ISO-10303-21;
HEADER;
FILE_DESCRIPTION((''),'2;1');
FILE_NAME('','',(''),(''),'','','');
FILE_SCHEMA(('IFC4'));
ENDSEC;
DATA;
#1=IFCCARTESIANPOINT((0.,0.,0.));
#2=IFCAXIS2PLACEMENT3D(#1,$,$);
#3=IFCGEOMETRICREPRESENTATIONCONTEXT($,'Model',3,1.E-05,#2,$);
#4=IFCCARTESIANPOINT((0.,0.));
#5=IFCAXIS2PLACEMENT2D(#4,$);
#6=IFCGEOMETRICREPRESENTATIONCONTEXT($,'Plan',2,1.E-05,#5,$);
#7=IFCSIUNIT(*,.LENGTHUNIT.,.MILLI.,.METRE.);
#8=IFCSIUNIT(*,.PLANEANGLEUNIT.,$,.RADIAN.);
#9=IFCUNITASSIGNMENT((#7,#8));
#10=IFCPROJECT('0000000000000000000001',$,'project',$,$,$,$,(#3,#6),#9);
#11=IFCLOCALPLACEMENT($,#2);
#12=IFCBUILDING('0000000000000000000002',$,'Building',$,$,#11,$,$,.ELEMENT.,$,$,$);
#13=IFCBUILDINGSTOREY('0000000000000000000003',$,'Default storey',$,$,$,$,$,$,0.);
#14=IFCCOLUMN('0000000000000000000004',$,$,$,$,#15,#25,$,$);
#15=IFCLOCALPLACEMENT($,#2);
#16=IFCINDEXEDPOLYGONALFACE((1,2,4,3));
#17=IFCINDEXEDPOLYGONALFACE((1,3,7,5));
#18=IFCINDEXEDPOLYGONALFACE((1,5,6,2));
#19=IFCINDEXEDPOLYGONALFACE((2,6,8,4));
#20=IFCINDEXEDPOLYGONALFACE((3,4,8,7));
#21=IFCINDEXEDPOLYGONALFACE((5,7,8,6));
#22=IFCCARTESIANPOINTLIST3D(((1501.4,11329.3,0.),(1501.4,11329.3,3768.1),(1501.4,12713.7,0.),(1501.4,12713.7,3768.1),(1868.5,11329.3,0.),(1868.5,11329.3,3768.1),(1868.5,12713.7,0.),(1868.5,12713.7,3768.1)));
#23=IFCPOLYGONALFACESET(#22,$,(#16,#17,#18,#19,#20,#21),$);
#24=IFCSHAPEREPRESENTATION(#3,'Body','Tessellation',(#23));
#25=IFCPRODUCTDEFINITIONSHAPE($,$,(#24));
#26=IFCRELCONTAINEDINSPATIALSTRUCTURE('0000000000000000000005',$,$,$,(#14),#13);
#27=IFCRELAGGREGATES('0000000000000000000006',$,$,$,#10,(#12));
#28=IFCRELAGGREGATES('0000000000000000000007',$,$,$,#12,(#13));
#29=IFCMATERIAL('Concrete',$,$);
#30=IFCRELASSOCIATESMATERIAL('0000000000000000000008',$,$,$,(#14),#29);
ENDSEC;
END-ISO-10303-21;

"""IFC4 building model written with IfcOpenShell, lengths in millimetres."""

from ifc_helpers import new_model, si_unit, frame, origin, origin_2d, place, context, project, spatial, rectangle, extrude, material, element, save


model = new_model("IFC4")

# Units and contexts
model_context = context("Model", 3, precision=1e-05, world=origin())
plan_context = context("Plan", 2, precision=1e-05, world=origin_2d())
ifc_project = project(units=[si_unit("LENGTHUNIT", "METRE", prefix="MILLI"), si_unit("PLANEANGLEUNIT", "RADIAN")], contexts=[model_context, plan_context])

# Building, storey
placement = place(None, origin())
building = spatial("IfcBuilding", under=ifc_project, at=placement, Name="Building", CompositionType="ELEMENT")
storey = spatial("IfcBuildingStorey", under=building, Name="Default storey", Elevation=0.0)

# Column
ifc_material_1 = material(Name="Concrete")
element("IfcColumn", 1, at=placement, inside=storey, material=ifc_material_1, context=model_context, shape_type="SweptSolid", body=[
    extrude(rectangle(XDim=367.1, YDim=1384.4, at=origin_2d()), frame((1685.0, 12021.5, 0.0), z_axis=(0.0, 0.0, 1.0), x_axis=(1000.0, 0.0, 0.0)), (0.0, 0.0, 1.0), 3768.1),
])

save(model, "model.ifc")
